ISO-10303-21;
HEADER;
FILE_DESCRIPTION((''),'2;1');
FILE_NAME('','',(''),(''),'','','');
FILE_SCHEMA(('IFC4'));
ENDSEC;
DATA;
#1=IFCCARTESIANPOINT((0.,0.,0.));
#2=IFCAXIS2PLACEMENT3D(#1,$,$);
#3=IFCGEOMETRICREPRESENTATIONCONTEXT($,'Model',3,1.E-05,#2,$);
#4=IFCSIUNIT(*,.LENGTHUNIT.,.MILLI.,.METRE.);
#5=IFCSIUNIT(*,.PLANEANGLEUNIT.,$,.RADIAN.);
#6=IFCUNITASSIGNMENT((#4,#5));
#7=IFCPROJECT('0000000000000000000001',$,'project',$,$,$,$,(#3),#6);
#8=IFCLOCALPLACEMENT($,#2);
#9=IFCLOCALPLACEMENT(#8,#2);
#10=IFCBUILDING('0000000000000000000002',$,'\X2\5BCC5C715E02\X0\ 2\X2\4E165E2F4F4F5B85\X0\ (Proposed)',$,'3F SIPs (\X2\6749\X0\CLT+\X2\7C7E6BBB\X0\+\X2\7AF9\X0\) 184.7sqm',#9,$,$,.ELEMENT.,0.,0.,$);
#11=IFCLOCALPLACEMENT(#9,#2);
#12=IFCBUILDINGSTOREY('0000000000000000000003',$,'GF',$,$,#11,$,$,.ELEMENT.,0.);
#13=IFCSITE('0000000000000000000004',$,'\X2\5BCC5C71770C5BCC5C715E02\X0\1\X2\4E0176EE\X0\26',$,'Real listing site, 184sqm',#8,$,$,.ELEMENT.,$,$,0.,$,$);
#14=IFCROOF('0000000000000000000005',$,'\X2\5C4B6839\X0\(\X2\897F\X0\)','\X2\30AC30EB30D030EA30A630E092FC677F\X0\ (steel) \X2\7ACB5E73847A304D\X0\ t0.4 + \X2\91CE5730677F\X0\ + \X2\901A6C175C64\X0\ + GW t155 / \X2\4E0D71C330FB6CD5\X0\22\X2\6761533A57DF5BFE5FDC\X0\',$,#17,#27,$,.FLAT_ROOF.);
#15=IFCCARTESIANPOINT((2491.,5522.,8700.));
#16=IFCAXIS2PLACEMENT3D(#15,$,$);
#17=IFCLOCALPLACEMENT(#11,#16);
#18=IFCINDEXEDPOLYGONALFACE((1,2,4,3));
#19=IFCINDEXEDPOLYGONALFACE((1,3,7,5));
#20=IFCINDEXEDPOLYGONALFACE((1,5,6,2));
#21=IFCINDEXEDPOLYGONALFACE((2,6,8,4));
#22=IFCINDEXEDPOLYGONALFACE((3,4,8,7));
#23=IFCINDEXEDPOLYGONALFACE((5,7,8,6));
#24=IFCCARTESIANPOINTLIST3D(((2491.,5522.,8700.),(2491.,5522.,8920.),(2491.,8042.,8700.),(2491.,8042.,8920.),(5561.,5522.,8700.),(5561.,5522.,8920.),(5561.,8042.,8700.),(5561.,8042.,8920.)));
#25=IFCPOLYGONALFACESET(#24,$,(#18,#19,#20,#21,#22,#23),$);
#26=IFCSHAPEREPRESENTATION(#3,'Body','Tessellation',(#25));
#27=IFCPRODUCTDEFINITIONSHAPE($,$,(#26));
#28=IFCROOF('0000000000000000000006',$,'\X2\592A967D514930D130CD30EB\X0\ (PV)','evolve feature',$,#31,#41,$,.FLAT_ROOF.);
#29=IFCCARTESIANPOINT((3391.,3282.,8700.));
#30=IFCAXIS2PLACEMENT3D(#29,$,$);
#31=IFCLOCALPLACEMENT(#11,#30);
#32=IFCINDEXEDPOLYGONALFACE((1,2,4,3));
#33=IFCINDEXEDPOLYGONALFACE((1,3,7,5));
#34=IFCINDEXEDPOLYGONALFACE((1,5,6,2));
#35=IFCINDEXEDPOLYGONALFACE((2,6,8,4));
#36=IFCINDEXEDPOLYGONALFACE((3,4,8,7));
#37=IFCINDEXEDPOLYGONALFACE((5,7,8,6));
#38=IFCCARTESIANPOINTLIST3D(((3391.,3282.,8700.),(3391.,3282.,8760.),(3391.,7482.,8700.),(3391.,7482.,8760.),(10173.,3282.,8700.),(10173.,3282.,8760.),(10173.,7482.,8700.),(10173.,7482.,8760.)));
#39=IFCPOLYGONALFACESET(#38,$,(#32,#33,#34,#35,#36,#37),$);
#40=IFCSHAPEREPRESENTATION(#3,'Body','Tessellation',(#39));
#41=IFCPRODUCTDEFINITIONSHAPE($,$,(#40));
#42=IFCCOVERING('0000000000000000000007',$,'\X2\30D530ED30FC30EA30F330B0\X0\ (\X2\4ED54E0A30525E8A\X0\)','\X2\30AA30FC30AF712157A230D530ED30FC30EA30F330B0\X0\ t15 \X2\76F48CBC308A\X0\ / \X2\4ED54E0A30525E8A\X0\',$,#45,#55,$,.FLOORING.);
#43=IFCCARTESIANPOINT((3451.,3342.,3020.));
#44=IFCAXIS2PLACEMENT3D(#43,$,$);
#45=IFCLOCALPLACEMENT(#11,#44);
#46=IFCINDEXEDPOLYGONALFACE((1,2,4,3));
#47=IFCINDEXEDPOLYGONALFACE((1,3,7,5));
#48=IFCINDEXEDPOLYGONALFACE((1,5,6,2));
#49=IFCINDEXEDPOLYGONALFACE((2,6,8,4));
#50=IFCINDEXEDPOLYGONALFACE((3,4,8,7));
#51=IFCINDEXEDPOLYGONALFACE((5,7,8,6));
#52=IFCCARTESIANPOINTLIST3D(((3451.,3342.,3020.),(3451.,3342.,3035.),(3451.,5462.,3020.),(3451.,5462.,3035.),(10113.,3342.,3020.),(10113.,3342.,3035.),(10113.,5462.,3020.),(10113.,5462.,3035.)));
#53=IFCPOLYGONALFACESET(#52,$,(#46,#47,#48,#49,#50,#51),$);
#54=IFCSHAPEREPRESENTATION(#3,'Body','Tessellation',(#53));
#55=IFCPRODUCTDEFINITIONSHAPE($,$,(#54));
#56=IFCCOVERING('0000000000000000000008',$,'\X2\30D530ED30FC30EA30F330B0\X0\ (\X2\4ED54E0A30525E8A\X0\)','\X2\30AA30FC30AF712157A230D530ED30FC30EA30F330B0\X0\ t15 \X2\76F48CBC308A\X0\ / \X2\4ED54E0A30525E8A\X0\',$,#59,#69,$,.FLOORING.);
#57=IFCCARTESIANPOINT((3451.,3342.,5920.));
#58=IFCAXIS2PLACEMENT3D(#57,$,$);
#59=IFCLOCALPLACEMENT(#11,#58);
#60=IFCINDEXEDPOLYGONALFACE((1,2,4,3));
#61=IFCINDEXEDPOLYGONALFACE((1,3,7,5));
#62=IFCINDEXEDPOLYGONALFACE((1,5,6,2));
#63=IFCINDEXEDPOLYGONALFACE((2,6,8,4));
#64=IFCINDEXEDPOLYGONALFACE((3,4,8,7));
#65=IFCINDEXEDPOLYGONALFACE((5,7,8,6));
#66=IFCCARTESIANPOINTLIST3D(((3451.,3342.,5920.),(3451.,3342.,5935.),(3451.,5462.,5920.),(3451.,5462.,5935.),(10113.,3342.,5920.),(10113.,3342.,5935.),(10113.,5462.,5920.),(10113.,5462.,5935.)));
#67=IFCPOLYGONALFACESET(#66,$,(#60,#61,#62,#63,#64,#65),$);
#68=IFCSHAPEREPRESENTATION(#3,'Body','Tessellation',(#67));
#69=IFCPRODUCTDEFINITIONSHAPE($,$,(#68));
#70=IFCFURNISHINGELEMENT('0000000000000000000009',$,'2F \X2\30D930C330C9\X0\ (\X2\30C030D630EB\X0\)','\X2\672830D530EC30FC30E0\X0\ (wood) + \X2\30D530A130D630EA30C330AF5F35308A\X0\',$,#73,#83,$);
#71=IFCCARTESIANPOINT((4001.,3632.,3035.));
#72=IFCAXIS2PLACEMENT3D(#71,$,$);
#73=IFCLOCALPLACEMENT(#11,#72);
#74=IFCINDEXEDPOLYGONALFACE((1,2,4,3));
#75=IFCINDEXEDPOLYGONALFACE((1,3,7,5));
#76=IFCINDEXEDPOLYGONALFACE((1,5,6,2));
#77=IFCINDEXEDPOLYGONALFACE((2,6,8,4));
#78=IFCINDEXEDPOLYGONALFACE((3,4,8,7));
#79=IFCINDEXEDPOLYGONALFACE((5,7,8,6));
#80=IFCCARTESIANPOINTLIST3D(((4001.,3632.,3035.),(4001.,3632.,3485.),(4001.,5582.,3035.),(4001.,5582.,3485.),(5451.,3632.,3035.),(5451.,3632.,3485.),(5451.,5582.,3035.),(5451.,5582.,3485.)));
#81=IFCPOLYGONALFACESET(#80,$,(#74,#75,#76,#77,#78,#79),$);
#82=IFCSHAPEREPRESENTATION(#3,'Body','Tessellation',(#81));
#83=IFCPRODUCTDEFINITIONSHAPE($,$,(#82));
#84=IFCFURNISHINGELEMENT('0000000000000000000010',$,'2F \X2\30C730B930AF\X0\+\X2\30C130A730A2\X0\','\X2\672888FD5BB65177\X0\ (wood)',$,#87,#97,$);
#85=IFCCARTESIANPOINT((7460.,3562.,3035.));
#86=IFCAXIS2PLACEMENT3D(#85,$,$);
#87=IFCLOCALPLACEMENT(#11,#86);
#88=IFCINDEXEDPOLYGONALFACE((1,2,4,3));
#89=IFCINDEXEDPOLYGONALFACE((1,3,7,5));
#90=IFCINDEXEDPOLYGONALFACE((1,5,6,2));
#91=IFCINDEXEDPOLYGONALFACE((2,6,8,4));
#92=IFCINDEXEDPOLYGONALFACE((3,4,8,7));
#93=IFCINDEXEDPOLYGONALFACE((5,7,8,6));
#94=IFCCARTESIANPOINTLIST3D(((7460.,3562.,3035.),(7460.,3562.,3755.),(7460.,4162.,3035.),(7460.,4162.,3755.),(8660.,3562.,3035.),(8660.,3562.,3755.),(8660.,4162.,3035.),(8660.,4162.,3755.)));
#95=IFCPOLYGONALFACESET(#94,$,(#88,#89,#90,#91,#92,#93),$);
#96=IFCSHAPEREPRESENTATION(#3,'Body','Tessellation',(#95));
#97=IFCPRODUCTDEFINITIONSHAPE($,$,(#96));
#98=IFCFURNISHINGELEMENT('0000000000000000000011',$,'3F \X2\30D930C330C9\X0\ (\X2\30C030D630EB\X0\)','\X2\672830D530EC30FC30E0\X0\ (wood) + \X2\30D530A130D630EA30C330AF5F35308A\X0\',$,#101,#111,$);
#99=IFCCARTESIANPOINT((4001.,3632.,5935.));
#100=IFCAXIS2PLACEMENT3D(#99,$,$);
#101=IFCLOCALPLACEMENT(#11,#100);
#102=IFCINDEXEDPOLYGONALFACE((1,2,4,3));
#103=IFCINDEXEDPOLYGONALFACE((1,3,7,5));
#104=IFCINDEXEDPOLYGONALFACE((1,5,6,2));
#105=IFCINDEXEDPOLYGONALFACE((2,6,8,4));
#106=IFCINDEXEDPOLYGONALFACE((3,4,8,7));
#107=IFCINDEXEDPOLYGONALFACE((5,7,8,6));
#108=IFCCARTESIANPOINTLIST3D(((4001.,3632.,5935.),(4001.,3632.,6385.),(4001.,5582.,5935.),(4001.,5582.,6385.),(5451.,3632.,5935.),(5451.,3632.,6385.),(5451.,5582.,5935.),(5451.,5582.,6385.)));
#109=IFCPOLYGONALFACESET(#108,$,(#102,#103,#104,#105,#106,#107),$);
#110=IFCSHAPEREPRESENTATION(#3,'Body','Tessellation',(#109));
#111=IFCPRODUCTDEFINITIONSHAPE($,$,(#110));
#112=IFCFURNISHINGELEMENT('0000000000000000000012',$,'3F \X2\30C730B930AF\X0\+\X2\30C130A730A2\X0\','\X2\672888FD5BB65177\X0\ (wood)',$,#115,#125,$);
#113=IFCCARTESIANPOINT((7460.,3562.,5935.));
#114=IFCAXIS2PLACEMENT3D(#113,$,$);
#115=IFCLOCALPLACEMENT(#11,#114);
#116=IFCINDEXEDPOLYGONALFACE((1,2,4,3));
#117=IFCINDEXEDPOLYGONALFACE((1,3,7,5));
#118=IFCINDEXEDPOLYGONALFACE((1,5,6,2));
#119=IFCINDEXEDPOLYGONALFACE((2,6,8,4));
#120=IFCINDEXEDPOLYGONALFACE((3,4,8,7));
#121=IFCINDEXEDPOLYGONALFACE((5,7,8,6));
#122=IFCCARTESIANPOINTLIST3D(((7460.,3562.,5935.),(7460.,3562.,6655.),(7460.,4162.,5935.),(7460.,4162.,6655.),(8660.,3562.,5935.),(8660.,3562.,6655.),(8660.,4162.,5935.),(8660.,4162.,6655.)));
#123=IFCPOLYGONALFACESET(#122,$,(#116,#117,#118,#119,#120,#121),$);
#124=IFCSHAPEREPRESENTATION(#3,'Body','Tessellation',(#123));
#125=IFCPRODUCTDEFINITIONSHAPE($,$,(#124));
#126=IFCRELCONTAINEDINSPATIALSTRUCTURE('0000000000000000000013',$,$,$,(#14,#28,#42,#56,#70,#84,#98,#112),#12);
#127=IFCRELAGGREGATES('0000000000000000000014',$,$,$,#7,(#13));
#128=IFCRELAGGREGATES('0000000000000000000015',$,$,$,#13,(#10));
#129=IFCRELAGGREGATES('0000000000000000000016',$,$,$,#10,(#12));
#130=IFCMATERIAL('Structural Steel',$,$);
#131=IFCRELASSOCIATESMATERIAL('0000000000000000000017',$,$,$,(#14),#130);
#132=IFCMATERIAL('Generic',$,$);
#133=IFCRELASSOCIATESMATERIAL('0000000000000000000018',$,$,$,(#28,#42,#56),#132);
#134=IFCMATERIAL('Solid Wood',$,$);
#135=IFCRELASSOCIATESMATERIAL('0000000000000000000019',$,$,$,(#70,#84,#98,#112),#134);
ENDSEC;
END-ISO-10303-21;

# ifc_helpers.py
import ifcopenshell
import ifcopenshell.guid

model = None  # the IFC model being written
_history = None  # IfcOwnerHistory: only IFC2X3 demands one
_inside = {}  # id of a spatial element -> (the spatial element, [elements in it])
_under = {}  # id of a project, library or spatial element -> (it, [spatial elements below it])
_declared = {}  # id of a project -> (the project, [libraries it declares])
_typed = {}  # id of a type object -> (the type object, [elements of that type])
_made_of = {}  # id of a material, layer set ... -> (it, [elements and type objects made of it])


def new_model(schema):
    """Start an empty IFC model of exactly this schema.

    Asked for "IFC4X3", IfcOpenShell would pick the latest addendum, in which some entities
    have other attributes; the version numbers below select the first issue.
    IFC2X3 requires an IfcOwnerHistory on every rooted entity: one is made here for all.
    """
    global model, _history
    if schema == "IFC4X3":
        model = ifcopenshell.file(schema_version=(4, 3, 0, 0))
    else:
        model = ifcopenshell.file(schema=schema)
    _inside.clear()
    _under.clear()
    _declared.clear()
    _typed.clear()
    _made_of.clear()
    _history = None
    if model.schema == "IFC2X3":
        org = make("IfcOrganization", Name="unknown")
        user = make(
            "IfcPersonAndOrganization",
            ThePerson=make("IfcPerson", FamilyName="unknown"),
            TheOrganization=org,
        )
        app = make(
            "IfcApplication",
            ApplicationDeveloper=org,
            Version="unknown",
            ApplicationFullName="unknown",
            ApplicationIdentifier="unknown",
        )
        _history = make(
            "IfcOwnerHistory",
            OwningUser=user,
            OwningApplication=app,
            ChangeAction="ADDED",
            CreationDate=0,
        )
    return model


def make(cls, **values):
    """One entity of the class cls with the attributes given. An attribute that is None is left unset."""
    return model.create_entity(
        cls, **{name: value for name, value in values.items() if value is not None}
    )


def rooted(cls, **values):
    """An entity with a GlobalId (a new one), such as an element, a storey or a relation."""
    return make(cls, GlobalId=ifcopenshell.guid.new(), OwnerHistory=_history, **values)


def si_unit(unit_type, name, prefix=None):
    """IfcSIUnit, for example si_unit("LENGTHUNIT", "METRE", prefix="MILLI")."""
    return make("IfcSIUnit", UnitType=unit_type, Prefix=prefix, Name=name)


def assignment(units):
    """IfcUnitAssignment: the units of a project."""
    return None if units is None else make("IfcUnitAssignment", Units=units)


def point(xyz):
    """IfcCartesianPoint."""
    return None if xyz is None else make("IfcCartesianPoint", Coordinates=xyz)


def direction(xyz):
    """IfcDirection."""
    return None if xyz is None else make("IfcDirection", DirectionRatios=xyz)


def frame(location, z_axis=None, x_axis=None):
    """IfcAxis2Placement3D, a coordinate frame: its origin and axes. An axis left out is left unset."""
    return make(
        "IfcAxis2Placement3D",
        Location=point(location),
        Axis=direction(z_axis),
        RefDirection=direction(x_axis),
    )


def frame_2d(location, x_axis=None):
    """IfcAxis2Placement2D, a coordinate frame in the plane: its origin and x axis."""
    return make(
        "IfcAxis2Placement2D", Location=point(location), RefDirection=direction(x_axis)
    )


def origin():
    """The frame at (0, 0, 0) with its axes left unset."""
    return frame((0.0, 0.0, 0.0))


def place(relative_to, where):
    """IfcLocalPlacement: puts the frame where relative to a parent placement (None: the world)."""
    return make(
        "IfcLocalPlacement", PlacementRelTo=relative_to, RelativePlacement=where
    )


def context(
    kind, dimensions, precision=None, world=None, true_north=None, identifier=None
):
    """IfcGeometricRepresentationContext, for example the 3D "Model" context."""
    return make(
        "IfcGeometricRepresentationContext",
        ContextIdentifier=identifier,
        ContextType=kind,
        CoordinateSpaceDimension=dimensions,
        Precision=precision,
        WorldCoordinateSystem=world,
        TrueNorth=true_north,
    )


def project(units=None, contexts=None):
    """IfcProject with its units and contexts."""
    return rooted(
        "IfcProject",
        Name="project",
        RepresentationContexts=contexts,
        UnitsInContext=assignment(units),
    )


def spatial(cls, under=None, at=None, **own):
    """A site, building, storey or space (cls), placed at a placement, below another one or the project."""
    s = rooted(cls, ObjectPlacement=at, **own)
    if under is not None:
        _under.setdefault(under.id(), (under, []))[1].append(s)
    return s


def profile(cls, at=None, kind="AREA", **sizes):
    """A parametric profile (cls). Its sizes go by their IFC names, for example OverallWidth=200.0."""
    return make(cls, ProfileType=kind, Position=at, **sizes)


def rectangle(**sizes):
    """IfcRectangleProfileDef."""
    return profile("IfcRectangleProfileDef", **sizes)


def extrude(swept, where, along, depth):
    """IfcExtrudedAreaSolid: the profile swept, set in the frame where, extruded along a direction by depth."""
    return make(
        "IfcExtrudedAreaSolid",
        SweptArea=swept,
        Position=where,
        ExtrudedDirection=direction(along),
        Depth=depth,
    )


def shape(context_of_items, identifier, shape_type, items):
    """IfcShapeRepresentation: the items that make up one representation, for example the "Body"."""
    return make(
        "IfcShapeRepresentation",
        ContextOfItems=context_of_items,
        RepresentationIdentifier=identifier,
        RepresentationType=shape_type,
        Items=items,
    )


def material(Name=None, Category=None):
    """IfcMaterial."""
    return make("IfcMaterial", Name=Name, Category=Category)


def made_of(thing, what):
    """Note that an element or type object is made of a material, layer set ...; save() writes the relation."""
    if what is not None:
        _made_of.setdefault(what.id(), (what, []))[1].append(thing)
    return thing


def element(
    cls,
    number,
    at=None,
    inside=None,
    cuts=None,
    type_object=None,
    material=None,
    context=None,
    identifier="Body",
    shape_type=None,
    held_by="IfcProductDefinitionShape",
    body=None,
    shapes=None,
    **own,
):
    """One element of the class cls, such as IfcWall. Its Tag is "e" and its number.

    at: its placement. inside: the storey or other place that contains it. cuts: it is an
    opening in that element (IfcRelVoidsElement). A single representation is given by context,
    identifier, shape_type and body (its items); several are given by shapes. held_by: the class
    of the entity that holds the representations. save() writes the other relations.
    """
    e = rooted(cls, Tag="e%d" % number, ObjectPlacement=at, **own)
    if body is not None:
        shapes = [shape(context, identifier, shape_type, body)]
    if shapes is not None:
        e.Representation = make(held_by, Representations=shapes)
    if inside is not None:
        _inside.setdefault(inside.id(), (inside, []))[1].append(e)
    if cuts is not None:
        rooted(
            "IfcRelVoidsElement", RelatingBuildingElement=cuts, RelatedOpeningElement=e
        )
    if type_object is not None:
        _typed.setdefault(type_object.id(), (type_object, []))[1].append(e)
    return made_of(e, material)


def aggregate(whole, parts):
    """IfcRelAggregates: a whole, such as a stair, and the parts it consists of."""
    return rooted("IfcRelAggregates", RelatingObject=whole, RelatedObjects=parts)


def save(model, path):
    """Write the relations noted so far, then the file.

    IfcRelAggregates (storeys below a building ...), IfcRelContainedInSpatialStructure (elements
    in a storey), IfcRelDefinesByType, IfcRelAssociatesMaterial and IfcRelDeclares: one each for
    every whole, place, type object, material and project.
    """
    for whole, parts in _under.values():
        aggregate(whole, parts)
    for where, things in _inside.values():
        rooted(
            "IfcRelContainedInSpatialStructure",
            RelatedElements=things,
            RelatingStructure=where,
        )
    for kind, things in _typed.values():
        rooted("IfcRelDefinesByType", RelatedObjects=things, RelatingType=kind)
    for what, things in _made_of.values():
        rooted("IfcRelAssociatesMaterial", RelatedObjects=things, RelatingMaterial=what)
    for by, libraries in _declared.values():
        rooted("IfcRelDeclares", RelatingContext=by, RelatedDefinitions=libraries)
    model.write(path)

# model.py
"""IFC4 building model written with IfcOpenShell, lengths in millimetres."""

from ifc_helpers import new_model, si_unit, frame, frame_2d, origin, place, context, project, spatial, rectangle, extrude, material, element, save


model = new_model("IFC4")

# Units and contexts
model_context = context("Model", 3, precision=1e-05, world=origin())
ifc_project = project(units=[si_unit("LENGTHUNIT", "METRE", prefix="MILLI"), si_unit("PLANEANGLEUNIT", "RADIAN")], contexts=[model_context])

# Site, building, storey
site_placement = place(None, origin())
site = spatial("IfcSite", under=ifc_project, at=site_placement, Name="富山県富山市1丁目26", ObjectType="Real listing site, 184sqm", CompositionType="ELEMENT", RefElevation=0.0)
building_placement = place(site_placement, origin())
building = spatial("IfcBuilding", under=site, at=building_placement, Name="富山市 2世帯住宅 (Proposed)", ObjectType="3F SIPs (杉CLT+籾殻+竹) 184.7sqm", CompositionType="ELEMENT", ElevationOfRefHeight=0.0, ElevationOfTerrain=0.0)
storey_placement = place(building_placement, origin())
storey = spatial("IfcBuildingStorey", under=building, at=storey_placement, Name="GF", CompositionType="ELEMENT", Elevation=0.0)

# Shared definitions
ifc_material_1 = material(Name="Solid Wood")

# Roofs
ifc_material_2 = material(Name="Structural Steel")
roof_1_placement = place(storey_placement, frame((2491.0, 5522.0, 8700.0)))
element("IfcRoof", 1, at=roof_1_placement, inside=storey, material=ifc_material_2, Name="屋根(西)", Description="ガルバリウム鋼板 (steel) 立平葺き t0.4 + 野地板 + 通気層 + GW t155 / 不燃・法22条区域対応", PredefinedType="FLAT_ROOF", context=model_context, shape_type="SweptSolid", body=[
    extrude(rectangle(XDim=3070.0, YDim=2520.0, at=frame_2d((1535.0, 1260.0))), frame((2491.0, 5522.0, 8700.0)), (0.0, 0.0, 1.0), 220.0),
])
ifc_material_3 = material(Name="Generic")
roof_2_placement = place(storey_placement, frame((3391.0, 3282.0, 8700.0)))
element("IfcRoof", 2, at=roof_2_placement, inside=storey, material=ifc_material_3, Name="太陽光パネル (PV)", Description="evolve feature", PredefinedType="FLAT_ROOF", context=model_context, shape_type="SweptSolid", body=[
    extrude(rectangle(XDim=6782.0, YDim=4200.0, at=frame_2d((3391.0, 2100.0))), frame((3391.0, 3282.0, 8700.0)), (0.0, 0.0, 1.0), 60.0),
])

# Coverings
covering_1_placement = place(storey_placement, frame((3451.0, 3342.0, 3020.0)))
element("IfcCovering", 3, at=covering_1_placement, inside=storey, material=ifc_material_3, Name="フローリング (仕上げ床)", Description="オーク無垢フローリング t15 直貼り / 仕上げ床", PredefinedType="FLOORING", context=model_context, shape_type="SweptSolid", body=[
    extrude(rectangle(XDim=6662.0, YDim=2120.0, at=frame_2d((3331.0, 1060.0))), frame((3451.0, 3342.0, 3020.0)), (0.0, 0.0, 1.0), 15.0),
])
covering_2_placement = place(storey_placement, frame((3451.0, 3342.0, 5920.0)))
element("IfcCovering", 4, at=covering_2_placement, inside=storey, material=ifc_material_3, Name="フローリング (仕上げ床)", Description="オーク無垢フローリング t15 直貼り / 仕上げ床", PredefinedType="FLOORING", context=model_context, shape_type="SweptSolid", body=[
    extrude(rectangle(XDim=6662.0, YDim=2120.0, at=frame_2d((3331.0, 1060.0))), frame((3451.0, 3342.0, 5920.0)), (0.0, 0.0, 1.0), 15.0),
])

# Furnishing elements
furnishing_1_placement = place(storey_placement, frame((4001.0, 3632.0, 3035.0)))
element("IfcFurnishingElement", 5, at=furnishing_1_placement, inside=storey, material=ifc_material_1, Name="2F ベッド (ダブル)", Description="木フレーム (wood) + ファブリック張り", context=model_context, shape_type="SweptSolid", body=[
    extrude(rectangle(XDim=1450.0, YDim=1950.0, at=frame_2d((725.0, 975.0))), frame((4001.0, 3632.0, 3035.0)), (0.0, 0.0, 1.0), 450.0),
])
furnishing_2_placement = place(storey_placement, frame((7460.0, 3562.0, 3035.0)))
element("IfcFurnishingElement", 6, at=furnishing_2_placement, inside=storey, material=ifc_material_1, Name="2F デスク+チェア", Description="木製家具 (wood)", context=model_context, shape_type="SweptSolid", body=[
    extrude(rectangle(XDim=1200.0, YDim=600.0, at=frame_2d((600.0, 300.0))), frame((7460.0, 3562.0, 3035.0)), (0.0, 0.0, 1.0), 720.0),
])
furnishing_3_placement = place(storey_placement, frame((4001.0, 3632.0, 5935.0)))
element("IfcFurnishingElement", 7, at=furnishing_3_placement, inside=storey, material=ifc_material_1, Name="3F ベッド (ダブル)", Description="木フレーム (wood) + ファブリック張り", context=model_context, shape_type="SweptSolid", body=[
    extrude(rectangle(XDim=1450.0, YDim=1950.0, at=frame_2d((725.0, 975.0))), frame((4001.0, 3632.0, 5935.0)), (0.0, 0.0, 1.0), 450.0),
])
furnishing_4_placement = place(storey_placement, frame((7460.0, 3562.0, 5935.0)))
element("IfcFurnishingElement", 8, at=furnishing_4_placement, inside=storey, material=ifc_material_1, Name="3F デスク+チェア", Description="木製家具 (wood)", context=model_context, shape_type="SweptSolid", body=[
    extrude(rectangle(XDim=1200.0, YDim=600.0, at=frame_2d((600.0, 300.0))), frame((7460.0, 3562.0, 5935.0)), (0.0, 0.0, 1.0), 720.0),
])

save(model, "model.ifc")
